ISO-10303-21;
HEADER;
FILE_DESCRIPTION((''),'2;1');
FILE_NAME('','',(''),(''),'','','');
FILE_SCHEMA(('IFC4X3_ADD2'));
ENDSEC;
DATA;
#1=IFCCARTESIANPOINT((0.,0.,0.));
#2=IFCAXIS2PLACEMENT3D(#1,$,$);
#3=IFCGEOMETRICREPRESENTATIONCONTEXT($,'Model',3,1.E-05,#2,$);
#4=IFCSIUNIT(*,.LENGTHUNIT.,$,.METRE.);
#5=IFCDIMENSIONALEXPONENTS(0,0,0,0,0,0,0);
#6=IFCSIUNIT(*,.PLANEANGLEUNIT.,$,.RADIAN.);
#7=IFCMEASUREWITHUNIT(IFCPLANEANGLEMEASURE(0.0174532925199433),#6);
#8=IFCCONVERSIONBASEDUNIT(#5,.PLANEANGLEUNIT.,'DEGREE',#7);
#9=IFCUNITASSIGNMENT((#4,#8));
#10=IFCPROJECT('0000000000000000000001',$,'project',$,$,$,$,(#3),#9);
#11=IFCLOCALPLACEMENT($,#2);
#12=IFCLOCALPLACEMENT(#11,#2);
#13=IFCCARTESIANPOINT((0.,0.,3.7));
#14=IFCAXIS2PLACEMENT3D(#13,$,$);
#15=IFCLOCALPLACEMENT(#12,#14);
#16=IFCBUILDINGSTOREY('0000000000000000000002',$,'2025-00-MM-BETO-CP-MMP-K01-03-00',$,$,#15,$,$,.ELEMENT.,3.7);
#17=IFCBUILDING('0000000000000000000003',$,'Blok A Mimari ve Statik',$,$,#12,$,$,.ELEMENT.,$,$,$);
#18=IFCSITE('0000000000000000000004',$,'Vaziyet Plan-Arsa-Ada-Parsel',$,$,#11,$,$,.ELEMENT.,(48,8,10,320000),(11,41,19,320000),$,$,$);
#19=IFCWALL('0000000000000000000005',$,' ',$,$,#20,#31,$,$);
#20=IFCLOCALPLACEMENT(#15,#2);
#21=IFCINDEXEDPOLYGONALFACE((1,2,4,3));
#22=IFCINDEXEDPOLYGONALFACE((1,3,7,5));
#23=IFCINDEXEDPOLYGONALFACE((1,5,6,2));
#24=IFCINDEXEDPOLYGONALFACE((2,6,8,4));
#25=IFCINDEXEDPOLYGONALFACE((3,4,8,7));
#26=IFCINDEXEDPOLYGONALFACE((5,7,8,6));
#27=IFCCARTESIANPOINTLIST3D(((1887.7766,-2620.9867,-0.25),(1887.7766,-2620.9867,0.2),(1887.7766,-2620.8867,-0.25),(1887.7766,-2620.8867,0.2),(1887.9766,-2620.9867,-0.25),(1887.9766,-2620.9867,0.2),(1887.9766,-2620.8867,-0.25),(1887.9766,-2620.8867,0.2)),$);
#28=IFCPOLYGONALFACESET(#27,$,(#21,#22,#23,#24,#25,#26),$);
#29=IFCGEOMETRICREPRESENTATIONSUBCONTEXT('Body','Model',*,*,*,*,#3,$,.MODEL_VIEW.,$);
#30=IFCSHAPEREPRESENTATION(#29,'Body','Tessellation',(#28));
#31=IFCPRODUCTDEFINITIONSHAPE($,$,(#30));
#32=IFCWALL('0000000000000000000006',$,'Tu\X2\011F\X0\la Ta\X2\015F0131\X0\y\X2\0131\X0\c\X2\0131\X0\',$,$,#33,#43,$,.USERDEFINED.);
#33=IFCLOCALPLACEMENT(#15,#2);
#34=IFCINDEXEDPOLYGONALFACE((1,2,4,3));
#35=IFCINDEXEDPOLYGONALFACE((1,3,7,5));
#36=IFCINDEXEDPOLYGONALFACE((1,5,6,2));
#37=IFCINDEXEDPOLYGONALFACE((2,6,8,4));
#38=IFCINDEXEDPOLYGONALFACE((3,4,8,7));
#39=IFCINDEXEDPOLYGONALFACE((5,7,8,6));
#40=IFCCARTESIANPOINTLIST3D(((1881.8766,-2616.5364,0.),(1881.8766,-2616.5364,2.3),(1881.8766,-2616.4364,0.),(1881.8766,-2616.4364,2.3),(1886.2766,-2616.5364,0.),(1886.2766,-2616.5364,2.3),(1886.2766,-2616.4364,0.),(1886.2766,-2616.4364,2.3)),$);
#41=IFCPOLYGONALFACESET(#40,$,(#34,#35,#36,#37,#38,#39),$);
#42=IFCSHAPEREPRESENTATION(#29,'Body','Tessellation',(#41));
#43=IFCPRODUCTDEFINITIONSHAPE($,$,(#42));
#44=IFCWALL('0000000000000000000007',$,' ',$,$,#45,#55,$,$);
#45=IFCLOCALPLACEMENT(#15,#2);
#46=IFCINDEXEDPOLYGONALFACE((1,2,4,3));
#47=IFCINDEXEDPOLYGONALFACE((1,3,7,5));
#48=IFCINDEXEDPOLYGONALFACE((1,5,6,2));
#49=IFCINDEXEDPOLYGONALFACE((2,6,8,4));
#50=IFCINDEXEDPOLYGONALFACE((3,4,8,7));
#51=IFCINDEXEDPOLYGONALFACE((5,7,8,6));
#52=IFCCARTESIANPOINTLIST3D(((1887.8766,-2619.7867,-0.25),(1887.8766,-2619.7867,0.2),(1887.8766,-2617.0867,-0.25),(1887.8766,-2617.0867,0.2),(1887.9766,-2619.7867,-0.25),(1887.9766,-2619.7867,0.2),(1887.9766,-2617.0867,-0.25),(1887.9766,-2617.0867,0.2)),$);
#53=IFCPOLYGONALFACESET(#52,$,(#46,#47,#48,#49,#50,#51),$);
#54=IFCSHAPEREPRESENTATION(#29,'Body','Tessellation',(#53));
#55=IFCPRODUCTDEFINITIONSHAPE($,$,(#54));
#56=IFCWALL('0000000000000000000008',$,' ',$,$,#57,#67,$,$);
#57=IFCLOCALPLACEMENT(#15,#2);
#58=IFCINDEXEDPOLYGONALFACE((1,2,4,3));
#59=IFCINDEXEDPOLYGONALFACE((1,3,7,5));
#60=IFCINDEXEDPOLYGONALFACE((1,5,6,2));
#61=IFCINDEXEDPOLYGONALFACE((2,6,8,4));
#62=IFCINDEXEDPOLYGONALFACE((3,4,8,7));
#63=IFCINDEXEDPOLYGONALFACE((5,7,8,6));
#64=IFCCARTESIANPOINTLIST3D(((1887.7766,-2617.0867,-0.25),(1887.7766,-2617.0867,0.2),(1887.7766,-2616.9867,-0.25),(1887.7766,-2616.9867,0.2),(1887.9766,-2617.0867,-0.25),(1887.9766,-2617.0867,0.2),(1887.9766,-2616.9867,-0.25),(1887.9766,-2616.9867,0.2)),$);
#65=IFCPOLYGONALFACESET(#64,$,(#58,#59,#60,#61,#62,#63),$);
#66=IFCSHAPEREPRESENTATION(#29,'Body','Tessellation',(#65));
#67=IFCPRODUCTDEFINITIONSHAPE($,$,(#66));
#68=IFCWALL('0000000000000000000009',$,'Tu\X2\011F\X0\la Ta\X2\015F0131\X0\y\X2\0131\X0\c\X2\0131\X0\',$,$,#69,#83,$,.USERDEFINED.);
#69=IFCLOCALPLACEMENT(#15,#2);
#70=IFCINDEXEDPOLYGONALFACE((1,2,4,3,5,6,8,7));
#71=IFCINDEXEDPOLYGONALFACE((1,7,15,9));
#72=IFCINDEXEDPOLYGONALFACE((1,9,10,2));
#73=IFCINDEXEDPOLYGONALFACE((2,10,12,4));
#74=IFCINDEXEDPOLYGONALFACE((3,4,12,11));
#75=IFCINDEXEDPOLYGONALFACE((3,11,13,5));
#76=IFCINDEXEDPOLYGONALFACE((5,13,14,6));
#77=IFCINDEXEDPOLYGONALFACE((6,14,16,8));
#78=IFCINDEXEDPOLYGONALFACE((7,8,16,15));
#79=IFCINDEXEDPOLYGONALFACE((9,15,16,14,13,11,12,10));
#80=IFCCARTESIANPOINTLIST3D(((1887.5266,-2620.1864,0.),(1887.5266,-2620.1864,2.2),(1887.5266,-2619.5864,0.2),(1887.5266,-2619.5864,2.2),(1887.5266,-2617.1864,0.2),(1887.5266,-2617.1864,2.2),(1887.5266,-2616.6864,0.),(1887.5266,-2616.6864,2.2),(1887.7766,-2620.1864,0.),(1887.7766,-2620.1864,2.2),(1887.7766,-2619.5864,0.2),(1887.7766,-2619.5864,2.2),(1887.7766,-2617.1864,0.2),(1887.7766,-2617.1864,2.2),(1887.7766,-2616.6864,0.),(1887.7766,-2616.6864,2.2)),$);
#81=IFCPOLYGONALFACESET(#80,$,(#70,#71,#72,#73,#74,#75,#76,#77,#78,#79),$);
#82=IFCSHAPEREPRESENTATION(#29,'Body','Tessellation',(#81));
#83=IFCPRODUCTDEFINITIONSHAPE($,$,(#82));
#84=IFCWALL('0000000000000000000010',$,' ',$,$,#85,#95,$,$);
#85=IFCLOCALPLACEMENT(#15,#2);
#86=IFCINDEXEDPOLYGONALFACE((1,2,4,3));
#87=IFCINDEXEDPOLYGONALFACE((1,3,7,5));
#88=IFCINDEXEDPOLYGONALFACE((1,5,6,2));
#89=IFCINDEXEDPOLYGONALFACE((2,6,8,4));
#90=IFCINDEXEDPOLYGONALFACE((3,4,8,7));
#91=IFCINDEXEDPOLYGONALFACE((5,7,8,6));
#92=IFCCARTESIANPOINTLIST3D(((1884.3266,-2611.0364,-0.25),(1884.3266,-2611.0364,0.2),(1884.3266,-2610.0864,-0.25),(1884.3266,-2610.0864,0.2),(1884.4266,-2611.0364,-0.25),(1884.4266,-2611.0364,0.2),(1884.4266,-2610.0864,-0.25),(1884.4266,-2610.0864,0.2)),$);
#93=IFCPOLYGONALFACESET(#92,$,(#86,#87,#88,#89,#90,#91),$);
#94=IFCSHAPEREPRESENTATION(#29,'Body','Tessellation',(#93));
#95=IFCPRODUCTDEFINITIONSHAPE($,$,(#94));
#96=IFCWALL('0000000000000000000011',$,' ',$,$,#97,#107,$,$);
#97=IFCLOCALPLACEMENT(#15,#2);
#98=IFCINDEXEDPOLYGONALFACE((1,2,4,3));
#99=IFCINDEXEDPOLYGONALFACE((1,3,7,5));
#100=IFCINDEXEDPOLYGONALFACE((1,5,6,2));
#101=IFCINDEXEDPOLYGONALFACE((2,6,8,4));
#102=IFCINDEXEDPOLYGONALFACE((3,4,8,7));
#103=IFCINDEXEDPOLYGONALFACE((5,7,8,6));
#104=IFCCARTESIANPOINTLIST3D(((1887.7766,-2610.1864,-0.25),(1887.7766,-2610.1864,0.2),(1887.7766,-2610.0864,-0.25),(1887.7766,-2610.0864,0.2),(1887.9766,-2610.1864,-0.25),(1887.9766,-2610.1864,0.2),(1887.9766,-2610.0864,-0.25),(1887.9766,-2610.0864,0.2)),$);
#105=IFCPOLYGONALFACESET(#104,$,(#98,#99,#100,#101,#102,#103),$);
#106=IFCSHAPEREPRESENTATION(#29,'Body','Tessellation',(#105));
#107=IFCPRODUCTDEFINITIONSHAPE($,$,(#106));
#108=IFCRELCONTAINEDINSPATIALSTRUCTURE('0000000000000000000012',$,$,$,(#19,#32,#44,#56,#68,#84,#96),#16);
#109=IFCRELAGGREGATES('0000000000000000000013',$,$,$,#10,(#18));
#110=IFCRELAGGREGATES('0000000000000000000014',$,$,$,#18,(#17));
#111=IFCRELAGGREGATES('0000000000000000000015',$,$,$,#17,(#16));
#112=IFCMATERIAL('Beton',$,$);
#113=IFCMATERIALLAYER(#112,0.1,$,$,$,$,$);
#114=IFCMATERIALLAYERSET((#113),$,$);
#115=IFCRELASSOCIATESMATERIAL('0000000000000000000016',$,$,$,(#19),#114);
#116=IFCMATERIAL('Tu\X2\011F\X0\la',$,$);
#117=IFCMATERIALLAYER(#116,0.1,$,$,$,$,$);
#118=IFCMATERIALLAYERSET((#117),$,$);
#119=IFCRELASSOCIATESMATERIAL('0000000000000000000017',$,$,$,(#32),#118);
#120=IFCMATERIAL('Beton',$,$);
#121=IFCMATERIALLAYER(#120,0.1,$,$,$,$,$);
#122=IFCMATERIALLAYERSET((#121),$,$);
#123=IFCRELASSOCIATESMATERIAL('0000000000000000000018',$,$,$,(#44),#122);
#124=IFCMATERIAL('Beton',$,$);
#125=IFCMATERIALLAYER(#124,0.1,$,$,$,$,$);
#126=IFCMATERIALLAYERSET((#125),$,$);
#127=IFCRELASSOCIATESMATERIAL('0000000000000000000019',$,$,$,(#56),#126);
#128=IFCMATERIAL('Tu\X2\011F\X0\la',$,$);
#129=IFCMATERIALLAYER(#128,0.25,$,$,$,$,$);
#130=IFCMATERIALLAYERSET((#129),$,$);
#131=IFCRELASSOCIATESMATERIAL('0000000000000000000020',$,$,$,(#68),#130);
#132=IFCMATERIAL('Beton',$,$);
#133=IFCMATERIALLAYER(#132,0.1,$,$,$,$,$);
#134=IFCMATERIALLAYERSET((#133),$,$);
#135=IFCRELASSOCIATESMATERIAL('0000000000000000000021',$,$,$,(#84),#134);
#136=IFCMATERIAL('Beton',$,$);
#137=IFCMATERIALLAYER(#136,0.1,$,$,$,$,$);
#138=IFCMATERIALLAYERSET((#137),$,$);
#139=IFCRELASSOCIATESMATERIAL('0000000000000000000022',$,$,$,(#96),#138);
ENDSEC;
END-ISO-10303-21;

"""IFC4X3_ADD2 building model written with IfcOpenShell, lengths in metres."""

from ifc_helpers import new_model, entity, si_unit, converted_unit, frame, frame_2d, origin, origin_with_axes, place, context, subcontext, project, spatial, polyline, rectangle, outline, extrude, material, layer, layer_set, layer_usage, element, save


model = new_model("IFC4X3_ADD2")

# Units and contexts
model_context = context("Model", 3, precision=1e-05, world=origin())
body_context = subcontext(model_context, "Body", "Model", "MODEL_VIEW")
ifc_project = project(units=[si_unit("LENGTHUNIT", "METRE"), converted_unit("PLANEANGLEUNIT", "DEGREE", entity("IfcPlaneAngleMeasure", 0.0174532925199433), si_unit("PLANEANGLEUNIT", "RADIAN"), dimensions=[0, 0, 0, 0, 0, 0, 0])], contexts=[model_context])

# Site, building, storey
site_placement = place(None, origin())
site = spatial("IfcSite", under=ifc_project, at=site_placement, Name="Vaziyet Plan-Arsa-Ada-Parsel", CompositionType="ELEMENT", RefLatitude=(48, 8, 10, 320000), RefLongitude=(11, 41, 19, 320000))
building_placement = place(site_placement, origin())
building = spatial("IfcBuilding", under=site, at=building_placement, Name="Blok A Mimari ve Statik", CompositionType="ELEMENT")
storey_placement = place(building_placement, frame((0.0, 0.0, 3.7)))
storey = spatial("IfcBuildingStorey", under=building, at=storey_placement, Name="2025-00-MM-BETO-CP-MMP-K01-03-00", CompositionType="ELEMENT", Elevation=3.7)

# Walls
ifc_material_1 = material(Name="Beton")
ifc_layer_1 = layer(ifc_material_1, 0.1)
ifc_layer_set_1 = layer_set([ifc_layer_1])
ifc_layer_usage_1 = layer_usage(ifc_layer_set_1, "AXIS2", "POSITIVE", 0.0)
wall_1_placement = place(storey_placement, frame((1887.9766, -2620.8867, -0.25), z_axis=(0.0, 0.0, 1.0), x_axis=(-1.0, 0.0, 0.0)))
element("IfcWall", 1, at=wall_1_placement, inside=storey, material=ifc_layer_usage_1, Name=" ", context=body_context, shape_type="SweptSolid", body=[
    extrude(rectangle(XDim=0.2, YDim=0.1, at=frame_2d((0.1, 0.05), x_axis=(1.0, 0.0))), origin_with_axes(), (0.0, 0.0, 1.0), 0.45),
])
ifc_material_2 = material(Name="Tuğla")
ifc_layer_2 = layer(ifc_material_2, 0.1)
ifc_layer_set_2 = layer_set([ifc_layer_2])
ifc_layer_usage_2 = layer_usage(ifc_layer_set_2, "AXIS2", "POSITIVE", 0.0)
wall_2_placement = place(storey_placement, frame((1886.2766, -2616.4364, 0.0), z_axis=(0.0, 0.0, 1.0), x_axis=(-1.0, 0.0, 0.0)))
element("IfcWall", 2, at=wall_2_placement, inside=storey, material=ifc_layer_usage_2, Name="Tuğla Taşıyıcı", PredefinedType="USERDEFINED", context=body_context, shape_type="SweptSolid", body=[
    extrude(rectangle(XDim=4.4, YDim=0.1, at=frame_2d((2.2, 0.05), x_axis=(1.0, 0.0))), origin_with_axes(), (0.0, 0.0, 1.0), 2.3),
])
ifc_material_3 = material(Name="Beton")
ifc_layer_3 = layer(ifc_material_3, 0.1)
ifc_layer_set_3 = layer_set([ifc_layer_3])
ifc_layer_usage_3 = layer_usage(ifc_layer_set_3, "AXIS2", "POSITIVE", 0.0)
wall_3_placement = place(storey_placement, frame((1887.9766, -2619.7867, -0.25), z_axis=(0.0, 0.0, 1.0), x_axis=(0.0, 1.0, 0.0)))
element("IfcWall", 3, at=wall_3_placement, inside=storey, material=ifc_layer_usage_3, Name=" ", context=body_context, shape_type="SweptSolid", body=[
    extrude(rectangle(XDim=2.7, YDim=0.1, at=frame_2d((1.35, 0.05), x_axis=(1.0, 0.0))), origin_with_axes(), (0.0, 0.0, 1.0), 0.45),
])
ifc_material_4 = material(Name="Beton")
ifc_layer_4 = layer(ifc_material_4, 0.1)
ifc_layer_set_4 = layer_set([ifc_layer_4])
ifc_layer_usage_4 = layer_usage(ifc_layer_set_4, "AXIS2", "POSITIVE", 0.0)
wall_4_placement = place(storey_placement, frame((1887.9766, -2616.9867, -0.25), z_axis=(0.0, 0.0, 1.0), x_axis=(-1.0, 0.0, 0.0)))
element("IfcWall", 4, at=wall_4_placement, inside=storey, material=ifc_layer_usage_4, Name=" ", context=body_context, shape_type="SweptSolid", body=[
    extrude(rectangle(XDim=0.2, YDim=0.1, at=frame_2d((0.1, 0.05), x_axis=(1.0, 0.0))), origin_with_axes(), (0.0, 0.0, 1.0), 0.45),
])

# Wall, opening
ifc_material_5 = material(Name="Tuğla")
ifc_layer_5 = layer(ifc_material_5, 0.25)
ifc_layer_set_5 = layer_set([ifc_layer_5])
ifc_layer_usage_5 = layer_usage(ifc_layer_set_5, "AXIS2", "POSITIVE", 0.0)
wall_5_placement = place(storey_placement, frame((1887.7766, -2620.1864, 0.0), z_axis=(0.0, 0.0, 1.0), x_axis=(0.0, 1.0, 0.0)))
wall_5 = element("IfcWall", 5, at=wall_5_placement, inside=storey, material=ifc_layer_usage_5, Name="Tuğla Taşıyıcı", PredefinedType="USERDEFINED", context=body_context, shape_type="SweptSolid", body=[
    extrude(rectangle(XDim=3.5, YDim=0.25, at=frame_2d((1.75, 0.125), x_axis=(1.0, 0.0))), origin_with_axes(), (0.0, 0.0, 1.0), 2.2),
])
opening_1_placement = place(wall_5_placement, frame((0.6, 0.0, 0.2), z_axis=(0.0, 1.0, 0.0), x_axis=(0.0, 0.0, 1.0)))
element("IfcOpeningElement", 6, at=opening_1_placement, cuts=wall_5, PredefinedType="OPENING", context=body_context, shape_type="SweptSolid", body=[
    extrude(outline(polyline([(2.1, 2.4), (2.1, 0.0), (0.0, 0.0), (0.0, 2.4), (2.1, 2.4)])), origin_with_axes(), (0.0, 0.0, 1.0), 0.25),
])

# Walls
ifc_material_6 = material(Name="Beton")
ifc_layer_6 = layer(ifc_material_6, 0.1)
ifc_layer_set_6 = layer_set([ifc_layer_6])
ifc_layer_usage_6 = layer_usage(ifc_layer_set_6, "AXIS2", "POSITIVE", 0.0)
wall_6_placement = place(storey_placement, frame((1884.3266, -2610.0864, -0.25), z_axis=(0.0, 0.0, 1.0), x_axis=(0.0, -1.0, 0.0)))
element("IfcWall", 7, at=wall_6_placement, inside=storey, material=ifc_layer_usage_6, Name=" ", context=body_context, shape_type="SweptSolid", body=[
    extrude(rectangle(XDim=0.95, YDim=0.1, at=frame_2d((0.475, 0.05), x_axis=(1.0, 0.0))), origin_with_axes(), (0.0, 0.0, 1.0), 0.45),
])
ifc_material_7 = material(Name="Beton")
ifc_layer_7 = layer(ifc_material_7, 0.1)
ifc_layer_set_7 = layer_set([ifc_layer_7])
ifc_layer_usage_7 = layer_usage(ifc_layer_set_7, "AXIS2", "POSITIVE", 0.0)
wall_7_placement = place(storey_placement, frame((1887.9766, -2610.0864, -0.25), z_axis=(0.0, 0.0, 1.0), x_axis=(-1.0, 0.0, 0.0)))
element("IfcWall", 8, at=wall_7_placement, inside=storey, material=ifc_layer_usage_7, Name=" ", context=body_context, shape_type="SweptSolid", body=[
    extrude(rectangle(XDim=0.2, YDim=0.1, at=frame_2d((0.1, 0.05), x_axis=(1.0, 0.0))), origin_with_axes(), (0.0, 0.0, 1.0), 0.45),
])

save(model, "model.ifc")
